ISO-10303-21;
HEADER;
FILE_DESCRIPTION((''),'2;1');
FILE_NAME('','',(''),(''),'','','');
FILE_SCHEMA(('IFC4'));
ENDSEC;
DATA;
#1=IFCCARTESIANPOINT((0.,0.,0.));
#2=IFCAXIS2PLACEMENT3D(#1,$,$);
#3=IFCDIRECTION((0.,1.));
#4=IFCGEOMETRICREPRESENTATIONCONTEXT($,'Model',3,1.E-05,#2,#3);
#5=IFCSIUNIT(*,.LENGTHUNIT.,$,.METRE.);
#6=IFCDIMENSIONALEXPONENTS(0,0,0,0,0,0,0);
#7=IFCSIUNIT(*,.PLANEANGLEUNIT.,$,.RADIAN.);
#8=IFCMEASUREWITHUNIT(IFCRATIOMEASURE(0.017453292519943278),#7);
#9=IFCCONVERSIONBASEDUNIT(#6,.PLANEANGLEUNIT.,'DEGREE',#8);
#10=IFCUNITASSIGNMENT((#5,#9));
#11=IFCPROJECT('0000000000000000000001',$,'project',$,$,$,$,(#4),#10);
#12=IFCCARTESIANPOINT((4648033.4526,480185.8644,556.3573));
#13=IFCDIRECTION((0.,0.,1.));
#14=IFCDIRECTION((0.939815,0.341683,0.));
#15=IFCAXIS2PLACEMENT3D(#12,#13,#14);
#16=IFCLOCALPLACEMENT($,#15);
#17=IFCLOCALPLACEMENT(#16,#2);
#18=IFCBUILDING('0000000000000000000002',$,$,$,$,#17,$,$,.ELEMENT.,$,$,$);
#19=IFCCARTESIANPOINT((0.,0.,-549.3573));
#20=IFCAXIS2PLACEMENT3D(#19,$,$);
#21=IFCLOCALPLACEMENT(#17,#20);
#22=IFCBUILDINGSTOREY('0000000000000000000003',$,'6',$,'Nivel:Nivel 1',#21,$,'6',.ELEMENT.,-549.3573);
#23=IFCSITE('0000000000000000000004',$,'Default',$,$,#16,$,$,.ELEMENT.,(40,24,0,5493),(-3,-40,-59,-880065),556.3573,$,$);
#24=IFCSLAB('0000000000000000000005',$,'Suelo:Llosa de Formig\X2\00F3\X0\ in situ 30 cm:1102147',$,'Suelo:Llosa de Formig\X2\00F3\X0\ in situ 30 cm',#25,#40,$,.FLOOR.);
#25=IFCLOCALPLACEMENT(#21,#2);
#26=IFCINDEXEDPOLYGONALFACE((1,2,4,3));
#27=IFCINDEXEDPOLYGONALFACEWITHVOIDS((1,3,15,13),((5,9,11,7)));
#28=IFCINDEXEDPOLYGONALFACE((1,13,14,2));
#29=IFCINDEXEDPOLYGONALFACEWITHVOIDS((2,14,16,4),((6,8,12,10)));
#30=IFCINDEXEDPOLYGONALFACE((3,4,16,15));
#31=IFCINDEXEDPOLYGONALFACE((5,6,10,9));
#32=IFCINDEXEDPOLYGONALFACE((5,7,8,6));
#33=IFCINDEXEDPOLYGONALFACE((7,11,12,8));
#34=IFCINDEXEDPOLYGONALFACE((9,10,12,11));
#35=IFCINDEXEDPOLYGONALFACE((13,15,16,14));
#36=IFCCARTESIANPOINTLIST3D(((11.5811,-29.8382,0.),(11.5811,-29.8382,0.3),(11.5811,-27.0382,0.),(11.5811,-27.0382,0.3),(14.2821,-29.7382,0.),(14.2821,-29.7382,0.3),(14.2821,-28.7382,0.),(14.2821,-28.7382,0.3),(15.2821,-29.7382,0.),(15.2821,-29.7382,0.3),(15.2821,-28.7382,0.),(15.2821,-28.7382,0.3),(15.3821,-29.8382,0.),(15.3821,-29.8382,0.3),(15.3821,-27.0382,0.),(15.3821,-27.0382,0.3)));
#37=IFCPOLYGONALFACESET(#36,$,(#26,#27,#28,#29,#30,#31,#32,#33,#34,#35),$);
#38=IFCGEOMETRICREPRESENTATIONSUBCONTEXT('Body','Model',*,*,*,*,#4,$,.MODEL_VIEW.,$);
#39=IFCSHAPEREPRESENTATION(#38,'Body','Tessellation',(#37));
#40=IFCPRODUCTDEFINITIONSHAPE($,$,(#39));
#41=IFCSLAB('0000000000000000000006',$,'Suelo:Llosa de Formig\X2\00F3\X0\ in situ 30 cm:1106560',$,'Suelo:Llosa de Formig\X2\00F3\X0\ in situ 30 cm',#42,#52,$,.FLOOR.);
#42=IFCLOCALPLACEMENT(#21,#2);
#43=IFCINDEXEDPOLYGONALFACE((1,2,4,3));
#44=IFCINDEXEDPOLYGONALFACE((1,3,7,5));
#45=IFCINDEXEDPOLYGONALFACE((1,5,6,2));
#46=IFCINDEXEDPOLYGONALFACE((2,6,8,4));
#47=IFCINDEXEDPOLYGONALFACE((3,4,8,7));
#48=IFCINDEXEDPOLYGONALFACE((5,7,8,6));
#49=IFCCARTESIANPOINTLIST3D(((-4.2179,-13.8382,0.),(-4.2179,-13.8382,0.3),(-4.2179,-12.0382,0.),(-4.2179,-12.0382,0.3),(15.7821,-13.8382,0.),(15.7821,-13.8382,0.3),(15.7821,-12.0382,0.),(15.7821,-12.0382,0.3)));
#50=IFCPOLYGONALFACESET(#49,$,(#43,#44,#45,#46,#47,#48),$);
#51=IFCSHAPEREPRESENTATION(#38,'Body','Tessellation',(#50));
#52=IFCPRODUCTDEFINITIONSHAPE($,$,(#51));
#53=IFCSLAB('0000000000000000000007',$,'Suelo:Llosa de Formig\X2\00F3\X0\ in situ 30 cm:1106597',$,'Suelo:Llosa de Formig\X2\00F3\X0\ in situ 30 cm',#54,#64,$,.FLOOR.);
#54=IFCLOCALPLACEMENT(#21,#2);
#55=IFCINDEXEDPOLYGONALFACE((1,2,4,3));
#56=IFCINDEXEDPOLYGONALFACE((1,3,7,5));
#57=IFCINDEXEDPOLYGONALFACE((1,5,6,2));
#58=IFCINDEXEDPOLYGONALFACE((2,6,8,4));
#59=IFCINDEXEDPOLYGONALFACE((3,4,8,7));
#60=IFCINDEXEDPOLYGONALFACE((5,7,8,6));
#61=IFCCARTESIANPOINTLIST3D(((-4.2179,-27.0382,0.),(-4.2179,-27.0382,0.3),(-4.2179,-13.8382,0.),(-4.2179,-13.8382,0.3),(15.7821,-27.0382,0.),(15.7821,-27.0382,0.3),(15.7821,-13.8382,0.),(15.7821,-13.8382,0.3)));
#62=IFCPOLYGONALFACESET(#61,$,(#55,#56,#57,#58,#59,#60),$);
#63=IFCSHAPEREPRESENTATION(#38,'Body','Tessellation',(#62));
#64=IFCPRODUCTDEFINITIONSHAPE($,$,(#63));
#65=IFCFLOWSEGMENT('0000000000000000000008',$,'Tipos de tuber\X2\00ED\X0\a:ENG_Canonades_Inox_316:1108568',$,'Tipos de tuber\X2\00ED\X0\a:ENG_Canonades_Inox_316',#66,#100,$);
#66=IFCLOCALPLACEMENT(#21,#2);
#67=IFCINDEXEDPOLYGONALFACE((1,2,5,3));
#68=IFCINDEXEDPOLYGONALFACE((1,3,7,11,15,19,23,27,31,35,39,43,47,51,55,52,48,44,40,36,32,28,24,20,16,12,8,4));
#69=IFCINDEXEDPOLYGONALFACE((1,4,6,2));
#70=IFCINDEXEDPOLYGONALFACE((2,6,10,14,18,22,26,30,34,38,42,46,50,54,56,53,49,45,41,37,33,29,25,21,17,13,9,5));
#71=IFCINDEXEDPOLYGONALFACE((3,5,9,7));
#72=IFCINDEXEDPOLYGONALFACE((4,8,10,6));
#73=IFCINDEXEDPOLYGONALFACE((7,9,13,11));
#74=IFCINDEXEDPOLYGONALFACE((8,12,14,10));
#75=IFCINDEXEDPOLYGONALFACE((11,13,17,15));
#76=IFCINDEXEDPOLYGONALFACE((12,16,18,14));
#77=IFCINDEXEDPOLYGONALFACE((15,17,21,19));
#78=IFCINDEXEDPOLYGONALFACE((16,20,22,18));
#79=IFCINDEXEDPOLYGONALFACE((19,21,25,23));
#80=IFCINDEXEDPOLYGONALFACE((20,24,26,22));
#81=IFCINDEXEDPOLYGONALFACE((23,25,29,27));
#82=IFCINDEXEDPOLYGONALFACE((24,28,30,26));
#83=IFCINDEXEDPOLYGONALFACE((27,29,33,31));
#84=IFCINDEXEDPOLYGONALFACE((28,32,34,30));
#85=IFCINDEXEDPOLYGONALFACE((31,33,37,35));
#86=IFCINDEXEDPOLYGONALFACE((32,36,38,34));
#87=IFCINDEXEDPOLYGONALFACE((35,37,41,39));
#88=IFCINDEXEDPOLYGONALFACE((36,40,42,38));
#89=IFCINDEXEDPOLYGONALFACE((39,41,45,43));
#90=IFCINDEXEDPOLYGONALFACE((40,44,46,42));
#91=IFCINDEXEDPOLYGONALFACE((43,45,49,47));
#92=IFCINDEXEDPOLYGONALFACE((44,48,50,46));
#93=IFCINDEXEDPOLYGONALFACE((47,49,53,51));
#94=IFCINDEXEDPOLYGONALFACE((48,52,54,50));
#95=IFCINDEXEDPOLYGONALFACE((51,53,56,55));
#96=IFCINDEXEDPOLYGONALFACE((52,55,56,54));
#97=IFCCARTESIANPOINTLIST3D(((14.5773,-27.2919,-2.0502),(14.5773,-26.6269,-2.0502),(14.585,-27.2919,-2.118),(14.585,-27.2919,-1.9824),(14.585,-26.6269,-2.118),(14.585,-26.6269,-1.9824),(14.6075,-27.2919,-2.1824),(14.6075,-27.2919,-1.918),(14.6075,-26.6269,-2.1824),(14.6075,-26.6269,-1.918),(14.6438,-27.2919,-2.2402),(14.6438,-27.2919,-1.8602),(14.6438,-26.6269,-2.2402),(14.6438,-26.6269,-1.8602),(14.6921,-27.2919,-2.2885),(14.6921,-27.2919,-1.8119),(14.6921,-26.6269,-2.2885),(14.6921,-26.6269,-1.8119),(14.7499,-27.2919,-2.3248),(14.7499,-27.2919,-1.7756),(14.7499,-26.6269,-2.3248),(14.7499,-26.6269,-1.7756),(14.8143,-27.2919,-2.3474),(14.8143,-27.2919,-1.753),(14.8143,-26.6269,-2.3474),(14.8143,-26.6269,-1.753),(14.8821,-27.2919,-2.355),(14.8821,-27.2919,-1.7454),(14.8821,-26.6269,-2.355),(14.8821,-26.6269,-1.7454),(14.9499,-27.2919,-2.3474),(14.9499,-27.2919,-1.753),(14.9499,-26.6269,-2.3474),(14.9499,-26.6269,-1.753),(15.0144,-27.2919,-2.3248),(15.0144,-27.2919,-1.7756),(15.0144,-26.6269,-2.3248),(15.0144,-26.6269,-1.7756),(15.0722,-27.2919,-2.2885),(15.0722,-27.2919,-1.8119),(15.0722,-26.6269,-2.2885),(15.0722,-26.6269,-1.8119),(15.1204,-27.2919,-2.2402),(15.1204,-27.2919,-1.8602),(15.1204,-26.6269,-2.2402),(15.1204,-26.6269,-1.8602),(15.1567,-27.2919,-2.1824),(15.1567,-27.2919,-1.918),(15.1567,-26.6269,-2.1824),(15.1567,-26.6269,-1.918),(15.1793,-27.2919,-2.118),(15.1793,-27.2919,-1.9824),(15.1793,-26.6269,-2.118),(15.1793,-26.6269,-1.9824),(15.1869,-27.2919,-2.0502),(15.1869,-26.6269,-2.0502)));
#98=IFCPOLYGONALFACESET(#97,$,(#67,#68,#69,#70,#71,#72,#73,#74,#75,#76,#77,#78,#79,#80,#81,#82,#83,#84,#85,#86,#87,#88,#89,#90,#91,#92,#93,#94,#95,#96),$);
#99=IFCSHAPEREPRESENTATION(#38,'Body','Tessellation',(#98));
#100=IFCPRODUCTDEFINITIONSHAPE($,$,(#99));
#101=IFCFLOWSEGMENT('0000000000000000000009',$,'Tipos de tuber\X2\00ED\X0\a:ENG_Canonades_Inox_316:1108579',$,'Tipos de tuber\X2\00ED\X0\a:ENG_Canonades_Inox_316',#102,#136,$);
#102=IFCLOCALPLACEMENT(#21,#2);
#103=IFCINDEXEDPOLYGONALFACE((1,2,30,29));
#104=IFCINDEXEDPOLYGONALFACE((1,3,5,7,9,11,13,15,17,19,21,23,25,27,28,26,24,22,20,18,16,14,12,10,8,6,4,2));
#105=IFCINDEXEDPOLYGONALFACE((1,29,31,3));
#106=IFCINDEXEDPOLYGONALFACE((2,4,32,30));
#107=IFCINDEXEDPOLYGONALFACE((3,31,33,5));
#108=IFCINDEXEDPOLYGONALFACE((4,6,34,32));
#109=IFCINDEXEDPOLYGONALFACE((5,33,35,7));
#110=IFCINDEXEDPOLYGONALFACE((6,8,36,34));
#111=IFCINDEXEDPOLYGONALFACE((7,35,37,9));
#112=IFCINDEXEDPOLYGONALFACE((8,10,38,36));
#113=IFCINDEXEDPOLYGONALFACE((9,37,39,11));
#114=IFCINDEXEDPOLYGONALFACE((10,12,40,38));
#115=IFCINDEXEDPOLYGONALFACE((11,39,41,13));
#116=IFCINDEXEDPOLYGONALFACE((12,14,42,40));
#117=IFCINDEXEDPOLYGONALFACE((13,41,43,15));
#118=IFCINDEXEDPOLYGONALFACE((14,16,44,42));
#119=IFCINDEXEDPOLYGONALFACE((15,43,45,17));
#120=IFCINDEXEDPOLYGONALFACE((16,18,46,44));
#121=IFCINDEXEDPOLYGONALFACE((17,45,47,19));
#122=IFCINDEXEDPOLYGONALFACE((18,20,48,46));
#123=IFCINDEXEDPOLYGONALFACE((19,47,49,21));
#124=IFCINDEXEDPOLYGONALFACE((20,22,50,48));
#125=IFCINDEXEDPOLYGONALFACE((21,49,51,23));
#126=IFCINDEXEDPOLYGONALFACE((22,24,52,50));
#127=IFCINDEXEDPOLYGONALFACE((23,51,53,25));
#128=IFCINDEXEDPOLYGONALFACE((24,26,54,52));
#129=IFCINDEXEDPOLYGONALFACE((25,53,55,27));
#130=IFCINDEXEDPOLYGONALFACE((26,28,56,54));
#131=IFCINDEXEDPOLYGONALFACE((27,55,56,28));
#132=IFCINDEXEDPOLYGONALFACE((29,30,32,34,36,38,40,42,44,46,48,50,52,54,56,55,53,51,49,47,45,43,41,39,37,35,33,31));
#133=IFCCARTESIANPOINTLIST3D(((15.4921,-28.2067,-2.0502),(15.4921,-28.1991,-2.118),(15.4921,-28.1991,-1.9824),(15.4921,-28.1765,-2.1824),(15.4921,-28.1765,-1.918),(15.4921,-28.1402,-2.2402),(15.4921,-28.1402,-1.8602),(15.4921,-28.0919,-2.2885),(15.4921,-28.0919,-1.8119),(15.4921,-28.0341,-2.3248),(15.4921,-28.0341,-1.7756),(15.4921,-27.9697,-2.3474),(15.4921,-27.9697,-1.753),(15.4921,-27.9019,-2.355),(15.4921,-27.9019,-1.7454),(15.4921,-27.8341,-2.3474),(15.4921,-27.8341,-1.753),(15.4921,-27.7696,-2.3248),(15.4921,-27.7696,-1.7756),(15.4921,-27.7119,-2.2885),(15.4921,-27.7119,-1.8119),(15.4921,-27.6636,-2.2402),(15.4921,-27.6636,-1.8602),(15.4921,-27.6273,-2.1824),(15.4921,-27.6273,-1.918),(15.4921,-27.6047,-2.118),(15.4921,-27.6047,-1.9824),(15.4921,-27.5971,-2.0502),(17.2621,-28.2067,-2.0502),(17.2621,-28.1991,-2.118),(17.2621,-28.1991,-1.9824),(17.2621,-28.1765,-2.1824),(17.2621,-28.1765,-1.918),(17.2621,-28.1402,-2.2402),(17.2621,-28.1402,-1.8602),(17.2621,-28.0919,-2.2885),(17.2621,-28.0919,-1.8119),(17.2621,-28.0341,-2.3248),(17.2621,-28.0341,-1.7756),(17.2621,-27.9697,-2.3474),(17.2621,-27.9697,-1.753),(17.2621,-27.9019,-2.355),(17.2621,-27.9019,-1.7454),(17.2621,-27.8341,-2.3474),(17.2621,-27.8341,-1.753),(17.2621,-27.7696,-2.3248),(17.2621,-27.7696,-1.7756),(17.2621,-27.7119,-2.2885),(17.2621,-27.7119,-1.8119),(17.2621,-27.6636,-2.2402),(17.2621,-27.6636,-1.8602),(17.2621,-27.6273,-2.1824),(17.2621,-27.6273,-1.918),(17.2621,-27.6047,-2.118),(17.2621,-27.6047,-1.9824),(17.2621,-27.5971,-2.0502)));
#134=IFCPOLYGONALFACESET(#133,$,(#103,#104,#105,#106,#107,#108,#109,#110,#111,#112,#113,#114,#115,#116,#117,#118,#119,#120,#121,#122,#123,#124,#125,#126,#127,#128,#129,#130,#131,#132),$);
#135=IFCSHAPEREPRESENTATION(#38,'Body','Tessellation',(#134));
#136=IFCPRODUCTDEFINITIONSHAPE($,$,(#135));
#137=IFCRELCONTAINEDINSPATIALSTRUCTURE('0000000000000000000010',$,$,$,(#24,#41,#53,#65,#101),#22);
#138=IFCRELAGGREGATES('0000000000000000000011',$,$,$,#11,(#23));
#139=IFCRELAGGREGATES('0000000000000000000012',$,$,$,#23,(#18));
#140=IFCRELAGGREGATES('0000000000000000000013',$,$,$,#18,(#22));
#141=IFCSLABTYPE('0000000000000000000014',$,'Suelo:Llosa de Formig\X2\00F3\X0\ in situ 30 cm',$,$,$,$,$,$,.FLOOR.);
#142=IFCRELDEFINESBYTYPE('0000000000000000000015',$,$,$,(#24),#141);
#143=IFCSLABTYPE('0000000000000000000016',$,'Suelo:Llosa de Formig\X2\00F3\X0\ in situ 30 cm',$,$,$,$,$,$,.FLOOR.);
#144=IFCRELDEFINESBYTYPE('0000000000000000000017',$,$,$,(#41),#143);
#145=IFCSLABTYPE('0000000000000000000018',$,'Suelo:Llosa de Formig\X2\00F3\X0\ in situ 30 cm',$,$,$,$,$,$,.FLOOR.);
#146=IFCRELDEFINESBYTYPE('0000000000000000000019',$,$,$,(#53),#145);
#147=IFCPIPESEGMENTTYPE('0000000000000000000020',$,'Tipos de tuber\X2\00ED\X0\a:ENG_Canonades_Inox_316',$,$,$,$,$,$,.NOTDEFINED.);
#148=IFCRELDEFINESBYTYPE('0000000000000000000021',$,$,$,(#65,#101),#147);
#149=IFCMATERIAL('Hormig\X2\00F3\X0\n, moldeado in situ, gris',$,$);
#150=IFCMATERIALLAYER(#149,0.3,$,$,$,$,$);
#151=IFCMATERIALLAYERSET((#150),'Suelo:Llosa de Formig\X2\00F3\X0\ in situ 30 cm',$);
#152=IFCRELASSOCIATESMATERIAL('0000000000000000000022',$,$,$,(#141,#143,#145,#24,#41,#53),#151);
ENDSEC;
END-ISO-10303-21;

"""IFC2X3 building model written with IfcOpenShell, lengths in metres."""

from ifc_helpers import new_model, entity, si_unit, converted_unit, direction, frame, frame_2d, origin, origin_2d_with_axis, place, context, subcontext, project, spatial, rectangle, circle, extrude, material, layer, layer_set, layer_usage, type_object, element, save


model = new_model("IFC2X3")

# Units and contexts
model_context = context("Model", 3, precision=1e-05, world=origin(), true_north=direction((0.0, 1.0)))
body_context = subcontext(model_context, "Body", "Model", "MODEL_VIEW")
ifc_project = project(units=[si_unit("LENGTHUNIT", "METRE"), converted_unit("PLANEANGLEUNIT", "DEGREE", entity("IfcRatioMeasure", 0.017453292519943278), si_unit("PLANEANGLEUNIT", "RADIAN"), dimensions=[0, 0, 0, 0, 0, 0, 0])], contexts=[model_context])

# Site, building, storey
site_placement = place(None, frame((4648033.4526, 480185.8644, 556.3573), z_axis=(0.0, 0.0, 1.0), x_axis=(0.939815, 0.341683, 0.0)))
site = spatial("IfcSite", under=ifc_project, at=site_placement, Name="Default", CompositionType="ELEMENT", RefLatitude=(40, 24, 0, 5493), RefLongitude=(-3, -40, -59, -880065), RefElevation=556.3573)
building_placement = place(site_placement, origin())
building = spatial("IfcBuilding", under=site, at=building_placement, CompositionType="ELEMENT")
storey_placement = place(building_placement, frame((0.0, 0.0, -549.3573)))
storey = spatial("IfcBuildingStorey", under=building, at=storey_placement, Name="6", ObjectType="Nivel:Nivel 1", LongName="6", CompositionType="ELEMENT", Elevation=-549.3573)

# Slab, opening
ifc_material_1 = material(Name="Hormigón, moldeado in situ, gris")
ifc_layer = layer(ifc_material_1, 0.3)
ifc_layer_set = layer_set([ifc_layer], Name="Suelo:Llosa de Formigó in situ 30 cm")
ifc_layer_usage_1 = layer_usage(ifc_layer_set, "AXIS3", "POSITIVE", 0.0)
slab_type_1 = type_object("IfcSlabType", Name="Suelo:Llosa de Formigó in situ 30 cm", PredefinedType="FLOOR", material=ifc_layer_set)
slab_1_placement = place(storey_placement, frame((11.5811, -29.8382, 0.0)))
slab_1 = element("IfcSlab", 1, at=slab_1_placement, inside=storey, type_object=slab_type_1, material=ifc_layer_usage_1, Name="Suelo:Llosa de Formigó in situ 30 cm:1102147", ObjectType="Suelo:Llosa de Formigó in situ 30 cm", PredefinedType="FLOOR", context=body_context, shape_type="SweptSolid", body=[
    extrude(rectangle(XDim=3.801, YDim=2.8, at=frame_2d((0.0, 0.0), x_axis=(-1.0, 0.0))), frame((1.9005, 1.4, 0.3), z_axis=(0.0, 0.0, -1.0), x_axis=(-1.0, 0.0, 0.0)), (0.0, 0.0, 1.0), 0.3),
])
opening_placement = place(slab_1_placement, frame((3.201, 0.6, 0.3)))
element("IfcOpeningElement", 2, at=opening_placement, cuts=slab_1, ObjectType="Opening", context=body_context, shape_type="SweptSolid", body=[
    extrude(rectangle(XDim=1.0, YDim=1.0, at=origin_2d_with_axis()), frame((0.0, 0.0, 0.0), z_axis=(0.0, 0.0, -1.0), x_axis=(0.0, -1.0, 0.0)), (0.0, 0.0, 1.0), 0.3),
])

# Slabs
ifc_layer_usage_2 = layer_usage(ifc_layer_set, "AXIS3", "POSITIVE", 0.0)
slab_type_2 = type_object("IfcSlabType", Name="Suelo:Llosa de Formigó in situ 30 cm", PredefinedType="FLOOR", material=ifc_layer_set)
slab_2_placement = place(storey_placement, origin())
element("IfcSlab", 3, at=slab_2_placement, inside=storey, type_object=slab_type_2, material=ifc_layer_usage_2, Name="Suelo:Llosa de Formigó in situ 30 cm:1106560", ObjectType="Suelo:Llosa de Formigó in situ 30 cm", PredefinedType="FLOOR", context=body_context, shape_type="SweptSolid", body=[
    extrude(rectangle(XDim=1.8, YDim=20.0, at=frame_2d((0.0, 0.0), x_axis=(1.0, 0.0))), frame((5.7821, -12.9382, 0.3), z_axis=(0.0, 0.0, -1.0), x_axis=(0.0, 1.0, 0.0)), (0.0, 0.0, 1.0), 0.3),
])
ifc_layer_usage_3 = layer_usage(ifc_layer_set, "AXIS3", "POSITIVE", 0.0)
slab_type_3 = type_object("IfcSlabType", Name="Suelo:Llosa de Formigó in situ 30 cm", PredefinedType="FLOOR", material=ifc_layer_set)
slab_3_placement = place(storey_placement, origin())
element("IfcSlab", 4, at=slab_3_placement, inside=storey, type_object=slab_type_3, material=ifc_layer_usage_3, Name="Suelo:Llosa de Formigó in situ 30 cm:1106597", ObjectType="Suelo:Llosa de Formigó in situ 30 cm", PredefinedType="FLOOR", context=body_context, shape_type="SweptSolid", body=[
    extrude(rectangle(XDim=13.2, YDim=20.0, at=origin_2d_with_axis()), frame((5.7821, -20.4382, 0.3), z_axis=(0.0, 0.0, -1.0), x_axis=(0.0, 1.0, 0.0)), (0.0, 0.0, 1.0), 0.3),
])

# Flow segments
pipe_segment_type = type_object("IfcPipeSegmentType", Name="Tipos de tubería:ENG_Canonades_Inox_316", PredefinedType="NOTDEFINED")
flow_segment_1_placement = place(storey_placement, origin())
element("IfcFlowSegment", 5, at=flow_segment_1_placement, inside=storey, type_object=pipe_segment_type, Name="Tipos de tubería:ENG_Canonades_Inox_316:1108568", ObjectType="Tipos de tubería:ENG_Canonades_Inox_316", context=body_context, shape_type="SweptSolid", body=[
    extrude(circle(Radius=0.3048, at=frame_2d((0.0, 0.0), x_axis=(1.0, 0.0))), frame((14.8821, -27.2919, -2.0502), z_axis=(0.0, 1.0, 0.0), x_axis=(1.0, 0.0, 0.0)), (0.0, 0.0, 1.0), 0.665),
])
flow_segment_2_placement = place(storey_placement, origin())
element("IfcFlowSegment", 6, at=flow_segment_2_placement, inside=storey, type_object=pipe_segment_type, Name="Tipos de tubería:ENG_Canonades_Inox_316:1108579", ObjectType="Tipos de tubería:ENG_Canonades_Inox_316", context=body_context, shape_type="SweptSolid", body=[
    extrude(circle(Radius=0.3048, at=origin_2d_with_axis()), frame((15.4921, -27.9019, -2.0502), z_axis=(1.0, 0.0, 0.0), x_axis=(0.0, -1.0, 0.0)), (0.0, 0.0, 1.0), 1.77),
])

save(model, "model.ifc")
